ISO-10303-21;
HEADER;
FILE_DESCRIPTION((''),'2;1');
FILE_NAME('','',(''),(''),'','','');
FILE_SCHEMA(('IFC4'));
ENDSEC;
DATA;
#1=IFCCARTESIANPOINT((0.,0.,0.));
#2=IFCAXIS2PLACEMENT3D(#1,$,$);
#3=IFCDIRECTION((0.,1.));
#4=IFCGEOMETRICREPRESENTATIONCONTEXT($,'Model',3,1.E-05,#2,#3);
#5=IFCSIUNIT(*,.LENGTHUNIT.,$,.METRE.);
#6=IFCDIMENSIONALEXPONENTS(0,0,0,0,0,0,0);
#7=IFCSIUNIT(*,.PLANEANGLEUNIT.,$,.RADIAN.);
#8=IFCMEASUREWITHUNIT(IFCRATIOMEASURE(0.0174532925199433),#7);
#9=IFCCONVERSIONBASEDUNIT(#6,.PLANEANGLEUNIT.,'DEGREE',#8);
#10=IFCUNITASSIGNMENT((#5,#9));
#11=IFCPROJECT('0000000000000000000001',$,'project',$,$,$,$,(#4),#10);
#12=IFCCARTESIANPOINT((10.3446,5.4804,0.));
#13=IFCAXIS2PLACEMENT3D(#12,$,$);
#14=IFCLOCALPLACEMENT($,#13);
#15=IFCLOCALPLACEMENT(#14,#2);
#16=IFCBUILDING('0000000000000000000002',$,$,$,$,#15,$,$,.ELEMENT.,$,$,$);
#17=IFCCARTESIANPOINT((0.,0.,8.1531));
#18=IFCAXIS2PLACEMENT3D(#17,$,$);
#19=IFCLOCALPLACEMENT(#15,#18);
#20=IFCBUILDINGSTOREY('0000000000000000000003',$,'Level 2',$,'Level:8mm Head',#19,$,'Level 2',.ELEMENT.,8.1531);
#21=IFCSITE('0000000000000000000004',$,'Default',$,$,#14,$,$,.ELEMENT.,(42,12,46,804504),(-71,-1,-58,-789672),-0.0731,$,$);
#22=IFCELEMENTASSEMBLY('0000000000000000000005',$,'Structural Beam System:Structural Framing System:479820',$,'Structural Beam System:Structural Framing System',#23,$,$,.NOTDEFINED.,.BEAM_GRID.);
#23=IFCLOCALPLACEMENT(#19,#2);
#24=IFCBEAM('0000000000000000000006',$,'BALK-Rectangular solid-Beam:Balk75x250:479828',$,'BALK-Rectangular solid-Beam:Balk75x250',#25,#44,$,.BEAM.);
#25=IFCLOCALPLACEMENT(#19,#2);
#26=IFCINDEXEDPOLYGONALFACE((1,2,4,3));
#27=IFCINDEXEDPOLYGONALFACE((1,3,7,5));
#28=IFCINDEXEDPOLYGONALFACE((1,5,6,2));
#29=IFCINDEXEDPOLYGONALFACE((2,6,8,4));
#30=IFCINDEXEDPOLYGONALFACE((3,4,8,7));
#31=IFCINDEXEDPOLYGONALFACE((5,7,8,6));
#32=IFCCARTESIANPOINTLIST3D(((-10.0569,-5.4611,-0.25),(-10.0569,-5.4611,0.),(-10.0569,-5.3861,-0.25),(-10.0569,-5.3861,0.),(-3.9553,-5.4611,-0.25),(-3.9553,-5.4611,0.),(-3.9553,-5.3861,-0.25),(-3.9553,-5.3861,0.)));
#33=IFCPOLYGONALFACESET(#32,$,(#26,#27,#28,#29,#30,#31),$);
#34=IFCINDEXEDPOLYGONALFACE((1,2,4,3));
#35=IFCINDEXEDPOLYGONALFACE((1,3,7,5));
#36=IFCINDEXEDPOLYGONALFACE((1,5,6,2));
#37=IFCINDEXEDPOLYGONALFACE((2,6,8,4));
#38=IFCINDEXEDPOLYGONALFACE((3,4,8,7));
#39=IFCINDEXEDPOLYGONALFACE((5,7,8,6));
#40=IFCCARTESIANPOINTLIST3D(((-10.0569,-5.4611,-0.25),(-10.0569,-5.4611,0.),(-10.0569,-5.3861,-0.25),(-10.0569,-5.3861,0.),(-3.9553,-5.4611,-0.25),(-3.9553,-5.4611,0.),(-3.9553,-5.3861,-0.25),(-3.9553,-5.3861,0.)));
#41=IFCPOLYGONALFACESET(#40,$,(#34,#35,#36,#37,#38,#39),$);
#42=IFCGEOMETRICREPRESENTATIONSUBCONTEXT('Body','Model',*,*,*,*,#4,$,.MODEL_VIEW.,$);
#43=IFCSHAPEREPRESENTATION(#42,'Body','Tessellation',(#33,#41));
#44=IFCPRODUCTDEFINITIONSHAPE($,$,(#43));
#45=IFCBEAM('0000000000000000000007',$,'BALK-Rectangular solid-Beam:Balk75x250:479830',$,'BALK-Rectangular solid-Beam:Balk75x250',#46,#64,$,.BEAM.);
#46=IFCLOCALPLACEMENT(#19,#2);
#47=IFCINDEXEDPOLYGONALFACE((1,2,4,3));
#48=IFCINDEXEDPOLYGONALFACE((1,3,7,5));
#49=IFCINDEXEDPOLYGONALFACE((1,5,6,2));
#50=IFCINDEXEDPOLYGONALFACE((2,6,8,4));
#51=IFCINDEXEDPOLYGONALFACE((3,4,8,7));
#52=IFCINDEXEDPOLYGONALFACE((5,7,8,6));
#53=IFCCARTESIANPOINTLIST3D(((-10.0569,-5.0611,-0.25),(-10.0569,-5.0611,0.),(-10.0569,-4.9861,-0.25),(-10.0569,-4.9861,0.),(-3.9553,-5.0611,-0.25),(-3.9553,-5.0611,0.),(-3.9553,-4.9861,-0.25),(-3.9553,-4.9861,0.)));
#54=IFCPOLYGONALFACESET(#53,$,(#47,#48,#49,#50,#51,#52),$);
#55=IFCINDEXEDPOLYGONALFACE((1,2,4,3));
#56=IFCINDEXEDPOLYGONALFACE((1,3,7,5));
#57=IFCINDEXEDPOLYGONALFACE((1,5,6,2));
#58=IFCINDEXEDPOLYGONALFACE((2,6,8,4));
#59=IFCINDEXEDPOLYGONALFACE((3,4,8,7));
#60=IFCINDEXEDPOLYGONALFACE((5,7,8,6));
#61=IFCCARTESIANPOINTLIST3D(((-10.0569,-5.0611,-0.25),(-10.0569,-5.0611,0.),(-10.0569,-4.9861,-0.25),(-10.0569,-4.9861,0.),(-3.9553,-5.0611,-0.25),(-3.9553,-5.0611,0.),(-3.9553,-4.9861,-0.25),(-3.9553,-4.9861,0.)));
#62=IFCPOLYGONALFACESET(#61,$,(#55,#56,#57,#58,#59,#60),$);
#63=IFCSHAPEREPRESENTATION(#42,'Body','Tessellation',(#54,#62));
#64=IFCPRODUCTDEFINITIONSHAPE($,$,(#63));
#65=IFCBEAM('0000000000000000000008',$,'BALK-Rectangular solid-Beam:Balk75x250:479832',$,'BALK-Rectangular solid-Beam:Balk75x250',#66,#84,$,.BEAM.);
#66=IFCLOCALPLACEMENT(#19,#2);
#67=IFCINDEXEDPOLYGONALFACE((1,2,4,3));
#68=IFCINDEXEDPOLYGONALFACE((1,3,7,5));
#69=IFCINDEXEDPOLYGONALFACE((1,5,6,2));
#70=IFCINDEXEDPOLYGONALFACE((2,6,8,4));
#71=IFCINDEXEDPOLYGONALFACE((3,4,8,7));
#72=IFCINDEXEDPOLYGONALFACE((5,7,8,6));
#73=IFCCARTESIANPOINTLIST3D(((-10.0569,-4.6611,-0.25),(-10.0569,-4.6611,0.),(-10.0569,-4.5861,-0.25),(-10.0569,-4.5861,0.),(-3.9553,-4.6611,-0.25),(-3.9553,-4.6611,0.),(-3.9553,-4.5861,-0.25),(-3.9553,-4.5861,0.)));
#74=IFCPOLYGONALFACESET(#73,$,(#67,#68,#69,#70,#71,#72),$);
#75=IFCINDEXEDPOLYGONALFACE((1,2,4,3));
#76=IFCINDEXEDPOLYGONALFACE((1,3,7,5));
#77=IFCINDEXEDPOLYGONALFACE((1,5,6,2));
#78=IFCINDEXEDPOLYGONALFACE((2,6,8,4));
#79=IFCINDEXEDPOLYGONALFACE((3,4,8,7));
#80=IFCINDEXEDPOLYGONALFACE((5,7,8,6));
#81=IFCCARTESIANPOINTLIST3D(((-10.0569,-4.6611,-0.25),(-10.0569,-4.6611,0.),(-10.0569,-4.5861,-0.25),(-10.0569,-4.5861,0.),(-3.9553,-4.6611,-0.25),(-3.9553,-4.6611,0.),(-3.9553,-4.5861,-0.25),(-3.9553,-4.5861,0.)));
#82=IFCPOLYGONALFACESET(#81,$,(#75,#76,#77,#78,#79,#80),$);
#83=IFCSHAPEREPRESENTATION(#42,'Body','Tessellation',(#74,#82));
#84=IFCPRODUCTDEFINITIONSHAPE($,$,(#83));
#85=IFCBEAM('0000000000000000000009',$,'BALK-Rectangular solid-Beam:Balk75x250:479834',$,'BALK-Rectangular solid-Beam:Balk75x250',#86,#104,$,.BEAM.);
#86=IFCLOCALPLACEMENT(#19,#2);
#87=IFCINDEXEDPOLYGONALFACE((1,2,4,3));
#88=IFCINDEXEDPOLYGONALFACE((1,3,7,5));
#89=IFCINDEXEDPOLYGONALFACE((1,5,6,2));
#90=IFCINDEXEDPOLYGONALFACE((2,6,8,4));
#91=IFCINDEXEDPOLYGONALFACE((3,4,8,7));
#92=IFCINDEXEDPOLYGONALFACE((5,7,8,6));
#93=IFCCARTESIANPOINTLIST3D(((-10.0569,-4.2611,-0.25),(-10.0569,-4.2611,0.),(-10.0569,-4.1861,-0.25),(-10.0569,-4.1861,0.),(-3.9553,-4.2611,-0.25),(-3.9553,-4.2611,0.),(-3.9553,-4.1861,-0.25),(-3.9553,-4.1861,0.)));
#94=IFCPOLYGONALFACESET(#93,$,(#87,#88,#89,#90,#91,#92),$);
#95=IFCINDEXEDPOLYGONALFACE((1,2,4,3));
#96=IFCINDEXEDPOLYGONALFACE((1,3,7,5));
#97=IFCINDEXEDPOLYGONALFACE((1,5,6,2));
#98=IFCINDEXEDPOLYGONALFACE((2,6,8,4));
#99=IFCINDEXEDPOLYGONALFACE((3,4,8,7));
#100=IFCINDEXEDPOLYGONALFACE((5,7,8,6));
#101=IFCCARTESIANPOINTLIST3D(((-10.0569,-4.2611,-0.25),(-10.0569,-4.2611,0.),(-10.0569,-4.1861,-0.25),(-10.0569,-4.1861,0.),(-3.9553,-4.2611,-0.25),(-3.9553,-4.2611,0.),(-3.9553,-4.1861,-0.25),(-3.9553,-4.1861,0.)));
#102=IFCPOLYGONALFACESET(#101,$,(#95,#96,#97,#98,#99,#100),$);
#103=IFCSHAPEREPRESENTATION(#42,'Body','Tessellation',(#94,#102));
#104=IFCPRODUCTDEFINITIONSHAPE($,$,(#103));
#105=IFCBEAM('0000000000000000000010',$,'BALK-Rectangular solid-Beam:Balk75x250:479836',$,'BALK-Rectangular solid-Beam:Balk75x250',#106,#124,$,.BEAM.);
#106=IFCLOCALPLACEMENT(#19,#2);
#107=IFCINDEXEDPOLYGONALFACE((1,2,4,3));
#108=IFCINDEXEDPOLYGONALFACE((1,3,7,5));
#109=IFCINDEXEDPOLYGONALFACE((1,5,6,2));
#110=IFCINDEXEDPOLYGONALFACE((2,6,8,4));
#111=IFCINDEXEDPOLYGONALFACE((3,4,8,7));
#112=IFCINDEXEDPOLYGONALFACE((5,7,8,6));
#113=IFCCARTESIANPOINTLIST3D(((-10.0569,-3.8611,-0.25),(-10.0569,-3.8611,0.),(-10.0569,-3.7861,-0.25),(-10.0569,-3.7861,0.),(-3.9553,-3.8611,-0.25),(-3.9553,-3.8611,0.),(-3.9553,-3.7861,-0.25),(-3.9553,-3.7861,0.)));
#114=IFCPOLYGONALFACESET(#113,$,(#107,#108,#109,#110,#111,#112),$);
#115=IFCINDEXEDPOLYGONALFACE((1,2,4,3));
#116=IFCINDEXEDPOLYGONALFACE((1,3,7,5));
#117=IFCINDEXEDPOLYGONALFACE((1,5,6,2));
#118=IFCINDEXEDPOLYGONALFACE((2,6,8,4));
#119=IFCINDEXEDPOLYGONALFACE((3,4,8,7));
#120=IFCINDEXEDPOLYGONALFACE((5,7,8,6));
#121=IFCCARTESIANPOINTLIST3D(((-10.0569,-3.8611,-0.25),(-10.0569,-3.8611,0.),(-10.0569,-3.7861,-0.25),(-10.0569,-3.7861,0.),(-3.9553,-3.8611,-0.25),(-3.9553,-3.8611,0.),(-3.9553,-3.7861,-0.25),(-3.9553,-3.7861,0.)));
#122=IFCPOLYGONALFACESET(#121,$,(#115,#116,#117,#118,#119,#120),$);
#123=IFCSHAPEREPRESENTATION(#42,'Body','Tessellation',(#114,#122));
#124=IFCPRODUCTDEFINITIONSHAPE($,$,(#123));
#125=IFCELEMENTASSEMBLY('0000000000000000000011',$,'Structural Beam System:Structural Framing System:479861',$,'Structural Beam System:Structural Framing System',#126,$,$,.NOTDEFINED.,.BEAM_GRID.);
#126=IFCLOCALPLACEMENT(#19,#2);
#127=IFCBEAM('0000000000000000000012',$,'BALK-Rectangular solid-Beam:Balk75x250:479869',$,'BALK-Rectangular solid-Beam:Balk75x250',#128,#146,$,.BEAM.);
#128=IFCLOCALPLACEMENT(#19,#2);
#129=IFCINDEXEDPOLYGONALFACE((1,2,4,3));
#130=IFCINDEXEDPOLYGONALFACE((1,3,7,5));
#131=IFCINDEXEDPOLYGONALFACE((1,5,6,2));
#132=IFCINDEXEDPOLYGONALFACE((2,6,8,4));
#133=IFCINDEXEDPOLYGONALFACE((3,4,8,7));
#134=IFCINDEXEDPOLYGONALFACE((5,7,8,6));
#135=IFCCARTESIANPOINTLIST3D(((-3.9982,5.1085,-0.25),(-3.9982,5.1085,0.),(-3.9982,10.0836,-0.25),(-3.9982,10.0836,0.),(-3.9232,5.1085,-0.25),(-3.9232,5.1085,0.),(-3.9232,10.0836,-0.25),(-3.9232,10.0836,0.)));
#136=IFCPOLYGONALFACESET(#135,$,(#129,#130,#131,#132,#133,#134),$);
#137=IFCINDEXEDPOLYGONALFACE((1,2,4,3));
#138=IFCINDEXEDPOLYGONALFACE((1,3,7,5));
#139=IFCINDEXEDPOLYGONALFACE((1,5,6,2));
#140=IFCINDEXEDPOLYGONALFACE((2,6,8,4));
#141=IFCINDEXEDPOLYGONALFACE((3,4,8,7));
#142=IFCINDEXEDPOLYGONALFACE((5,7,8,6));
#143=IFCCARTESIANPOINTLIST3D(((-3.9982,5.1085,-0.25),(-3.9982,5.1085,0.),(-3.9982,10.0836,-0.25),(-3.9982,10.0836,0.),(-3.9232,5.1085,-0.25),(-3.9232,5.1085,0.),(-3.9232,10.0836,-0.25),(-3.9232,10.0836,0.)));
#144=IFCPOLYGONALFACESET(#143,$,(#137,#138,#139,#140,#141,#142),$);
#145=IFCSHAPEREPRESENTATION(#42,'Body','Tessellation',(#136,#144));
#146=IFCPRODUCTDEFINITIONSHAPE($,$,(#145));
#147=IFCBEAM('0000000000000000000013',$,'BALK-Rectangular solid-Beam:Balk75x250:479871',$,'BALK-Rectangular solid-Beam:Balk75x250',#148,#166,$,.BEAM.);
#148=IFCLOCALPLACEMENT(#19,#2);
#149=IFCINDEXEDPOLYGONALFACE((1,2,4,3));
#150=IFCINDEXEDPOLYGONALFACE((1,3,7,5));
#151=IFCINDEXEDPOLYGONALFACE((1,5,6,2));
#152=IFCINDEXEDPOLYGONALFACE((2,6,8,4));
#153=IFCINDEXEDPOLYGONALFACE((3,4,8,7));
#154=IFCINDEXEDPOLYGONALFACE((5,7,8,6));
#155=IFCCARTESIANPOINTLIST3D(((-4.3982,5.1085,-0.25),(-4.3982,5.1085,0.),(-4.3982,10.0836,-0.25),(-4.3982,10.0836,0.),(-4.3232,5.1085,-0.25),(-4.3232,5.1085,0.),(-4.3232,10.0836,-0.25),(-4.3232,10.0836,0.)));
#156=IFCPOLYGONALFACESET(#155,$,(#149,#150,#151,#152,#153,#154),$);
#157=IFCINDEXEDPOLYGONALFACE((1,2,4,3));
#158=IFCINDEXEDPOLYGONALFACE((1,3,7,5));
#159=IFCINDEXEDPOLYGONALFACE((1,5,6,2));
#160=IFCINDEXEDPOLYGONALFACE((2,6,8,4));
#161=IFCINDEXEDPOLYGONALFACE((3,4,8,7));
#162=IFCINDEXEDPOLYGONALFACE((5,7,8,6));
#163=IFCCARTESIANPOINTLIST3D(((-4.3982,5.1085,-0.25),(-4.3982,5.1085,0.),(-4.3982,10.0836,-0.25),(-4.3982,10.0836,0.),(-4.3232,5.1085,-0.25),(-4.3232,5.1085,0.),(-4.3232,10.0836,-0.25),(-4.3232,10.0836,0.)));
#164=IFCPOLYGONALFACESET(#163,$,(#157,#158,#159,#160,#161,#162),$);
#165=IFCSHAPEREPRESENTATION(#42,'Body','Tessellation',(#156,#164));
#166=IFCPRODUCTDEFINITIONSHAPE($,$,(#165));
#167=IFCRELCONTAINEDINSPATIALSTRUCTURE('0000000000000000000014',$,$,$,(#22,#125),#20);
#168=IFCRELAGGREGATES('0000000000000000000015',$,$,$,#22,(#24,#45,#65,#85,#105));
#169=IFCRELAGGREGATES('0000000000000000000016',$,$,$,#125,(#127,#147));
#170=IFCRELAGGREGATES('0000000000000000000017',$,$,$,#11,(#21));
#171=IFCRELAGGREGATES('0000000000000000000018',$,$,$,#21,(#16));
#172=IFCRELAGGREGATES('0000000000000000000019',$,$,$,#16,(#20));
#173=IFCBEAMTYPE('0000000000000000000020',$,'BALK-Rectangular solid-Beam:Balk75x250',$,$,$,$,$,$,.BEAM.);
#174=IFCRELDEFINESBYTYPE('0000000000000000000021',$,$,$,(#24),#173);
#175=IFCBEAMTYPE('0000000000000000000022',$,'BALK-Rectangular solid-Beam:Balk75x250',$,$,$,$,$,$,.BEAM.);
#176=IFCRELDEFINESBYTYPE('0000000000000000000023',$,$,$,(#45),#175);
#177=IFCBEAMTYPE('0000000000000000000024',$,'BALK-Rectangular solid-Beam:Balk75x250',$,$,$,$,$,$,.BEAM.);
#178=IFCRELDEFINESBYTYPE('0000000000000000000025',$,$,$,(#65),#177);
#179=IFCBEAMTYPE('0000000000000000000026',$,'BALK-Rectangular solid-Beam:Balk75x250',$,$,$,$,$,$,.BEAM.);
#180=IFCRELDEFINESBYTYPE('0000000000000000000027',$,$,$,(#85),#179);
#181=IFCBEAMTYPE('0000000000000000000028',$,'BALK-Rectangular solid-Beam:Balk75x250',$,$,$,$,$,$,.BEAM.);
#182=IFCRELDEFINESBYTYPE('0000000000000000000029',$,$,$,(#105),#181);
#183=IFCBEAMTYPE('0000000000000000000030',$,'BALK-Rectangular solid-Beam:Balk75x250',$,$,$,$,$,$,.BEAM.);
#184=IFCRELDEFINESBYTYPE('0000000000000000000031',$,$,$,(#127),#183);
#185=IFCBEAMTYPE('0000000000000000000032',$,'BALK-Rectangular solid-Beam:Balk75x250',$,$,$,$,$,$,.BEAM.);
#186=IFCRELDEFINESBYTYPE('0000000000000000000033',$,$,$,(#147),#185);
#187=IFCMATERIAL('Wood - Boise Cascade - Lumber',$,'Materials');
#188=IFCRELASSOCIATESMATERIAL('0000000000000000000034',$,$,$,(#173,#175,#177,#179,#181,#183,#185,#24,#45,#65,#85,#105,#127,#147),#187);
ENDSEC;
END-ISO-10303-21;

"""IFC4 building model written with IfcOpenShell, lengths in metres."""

from ifc_helpers import new_model, entity, si_unit, converted_unit, direction, frame, frame_2d, origin, place, context, subcontext, project, spatial, rectangle, extrude, source, transform, mapped, material, material_profile, profile_set, profile_usage, type_object, type_shapes, element, aggregate, save


model = new_model("IFC4")

# Units and contexts
model_context = context("Model", 3, precision=1e-05, world=origin(), true_north=direction((0.0, 1.0)))
body_context = subcontext(model_context, "Body", "Model", "MODEL_VIEW")
ifc_project = project(units=[si_unit("LENGTHUNIT", "METRE"), converted_unit("PLANEANGLEUNIT", "DEGREE", entity("IfcRatioMeasure", 0.0174532925199433), si_unit("PLANEANGLEUNIT", "RADIAN"), dimensions=[0, 0, 0, 0, 0, 0, 0])], contexts=[model_context])

# Site, building, storey
site_placement = place(None, frame((10.3446, 5.4804, 0.0)))
site = spatial("IfcSite", under=ifc_project, at=site_placement, Name="Default", CompositionType="ELEMENT", RefLatitude=(42, 12, 46, 804504), RefLongitude=(-71, -1, -58, -789672), RefElevation=-0.0731)
building_placement = place(site_placement, origin())
building = spatial("IfcBuilding", under=site, at=building_placement, CompositionType="ELEMENT")
storey_placement = place(building_placement, frame((0.0, 0.0, 8.1531)))
storey = spatial("IfcBuildingStorey", under=building, at=storey_placement, Name="Level 2", ObjectType="Level:8mm Head", LongName="Level 2", CompositionType="ELEMENT", Elevation=8.1531)

# Element assemblies, beams
assembly_1_placement = place(storey_placement, origin())
assembly_1 = element("IfcElementAssembly", 1, at=assembly_1_placement, inside=storey, Name="Structural Beam System:Structural Framing System:479820", ObjectType="Structural Beam System:Structural Framing System", AssemblyPlace="NOTDEFINED", PredefinedType="BEAM_GRID")
ifc_material = material(Name="Wood - Boise Cascade - Lumber", Category="Materials")
ifc_material_profile = material_profile(ifc_material, rectangle(XDim=0.25, YDim=0.075, at=frame_2d((0.0, 0.0), x_axis=(1.0, 0.0))), Name="Balk75x250")
ifc_profile_set = profile_set([ifc_material_profile], Name="Balk75x250")
ifc_profile_usage_1 = profile_usage(ifc_profile_set, cardinal=8)
beam_type_1 = type_object("IfcBeamType", Name="BALK-Rectangular solid-Beam:Balk75x250", PredefinedType="BEAM", material=ifc_profile_set)
shared_shape_1 = source(origin(), body_context, "Body", "SweptSolid", [
    extrude(rectangle(XDim=0.25, YDim=0.075, at=frame_2d((0.0, 0.0), x_axis=(1.0, 0.0))), frame((-10.0569, -5.4236, 8.0281), z_axis=(1.0, 0.0, 0.0), x_axis=(0.0, 0.0, -1.0)), (0.0, 0.0, 1.0), 6.1016),
    extrude(rectangle(XDim=0.25, YDim=0.075, at=frame_2d((0.0, 0.0), x_axis=(1.0, 0.0))), frame((-10.0569, -5.4236, 8.0281), z_axis=(1.0, 0.0, 0.0), x_axis=(0.0, 0.0, -1.0)), (0.0, 0.0, 1.0), 6.1016),
])
type_shapes(beam_type_1, [shared_shape_1])
beam_1_placement = place(assembly_1_placement, frame((0.0, 0.0, -8.1531)))
beam_1 = element("IfcBeam", 2, at=beam_1_placement, type_object=beam_type_1, material=ifc_profile_usage_1, Name="BALK-Rectangular solid-Beam:Balk75x250:479828", ObjectType="BALK-Rectangular solid-Beam:Balk75x250", PredefinedType="BEAM", context=body_context, shape_type="MappedRepresentation", body=[
    mapped(shared_shape_1, transform((0.0, 0.0, 0.0), scale=1.0)),
])
ifc_profile_usage_2 = profile_usage(ifc_profile_set, cardinal=8)
beam_type_2 = type_object("IfcBeamType", Name="BALK-Rectangular solid-Beam:Balk75x250", PredefinedType="BEAM", material=ifc_profile_set)
shared_shape_2 = source(origin(), body_context, "Body", "SweptSolid", [
    extrude(rectangle(XDim=0.25, YDim=0.075, at=frame_2d((0.0, 0.0), x_axis=(1.0, 0.0))), frame((-10.0569, -5.0236, 8.0281), z_axis=(1.0, 0.0, 0.0), x_axis=(0.0, 0.0, -1.0)), (0.0, 0.0, 1.0), 6.1016),
    extrude(rectangle(XDim=0.25, YDim=0.075, at=frame_2d((0.0, 0.0), x_axis=(1.0, 0.0))), frame((-10.0569, -5.0236, 8.0281), z_axis=(1.0, 0.0, 0.0), x_axis=(0.0, 0.0, -1.0)), (0.0, 0.0, 1.0), 6.1016),
])
type_shapes(beam_type_2, [shared_shape_2])
beam_2_placement = place(assembly_1_placement, frame((0.0, 0.0, -8.1531)))
beam_2 = element("IfcBeam", 3, at=beam_2_placement, type_object=beam_type_2, material=ifc_profile_usage_2, Name="BALK-Rectangular solid-Beam:Balk75x250:479830", ObjectType="BALK-Rectangular solid-Beam:Balk75x250", PredefinedType="BEAM", context=body_context, shape_type="MappedRepresentation", body=[
    mapped(shared_shape_2, transform((0.0, 0.0, 0.0), scale=1.0)),
])
ifc_profile_usage_3 = profile_usage(ifc_profile_set, cardinal=8)
beam_type_3 = type_object("IfcBeamType", Name="BALK-Rectangular solid-Beam:Balk75x250", PredefinedType="BEAM", material=ifc_profile_set)
shared_shape_3 = source(origin(), body_context, "Body", "SweptSolid", [
    extrude(rectangle(XDim=0.25, YDim=0.075, at=frame_2d((0.0, 0.0), x_axis=(1.0, 0.0))), frame((-10.0569, -4.6236, 8.0281), z_axis=(1.0, 0.0, 0.0), x_axis=(0.0, 0.0, -1.0)), (0.0, 0.0, 1.0), 6.1016),
    extrude(rectangle(XDim=0.25, YDim=0.075, at=frame_2d((0.0, 0.0), x_axis=(1.0, 0.0))), frame((-10.0569, -4.6236, 8.0281), z_axis=(1.0, 0.0, 0.0), x_axis=(0.0, 0.0, -1.0)), (0.0, 0.0, 1.0), 6.1016),
])
type_shapes(beam_type_3, [shared_shape_3])
beam_3_placement = place(assembly_1_placement, frame((0.0, 0.0, -8.1531)))
beam_3 = element("IfcBeam", 4, at=beam_3_placement, type_object=beam_type_3, material=ifc_profile_usage_3, Name="BALK-Rectangular solid-Beam:Balk75x250:479832", ObjectType="BALK-Rectangular solid-Beam:Balk75x250", PredefinedType="BEAM", context=body_context, shape_type="MappedRepresentation", body=[
    mapped(shared_shape_3, transform((0.0, 0.0, 0.0), scale=1.0)),
])
ifc_profile_usage_4 = profile_usage(ifc_profile_set, cardinal=8)
beam_type_4 = type_object("IfcBeamType", Name="BALK-Rectangular solid-Beam:Balk75x250", PredefinedType="BEAM", material=ifc_profile_set)
shared_shape_4 = source(origin(), body_context, "Body", "SweptSolid", [
    extrude(rectangle(XDim=0.25, YDim=0.075, at=frame_2d((0.0, 0.0), x_axis=(1.0, 0.0))), frame((-10.0569, -4.2236, 8.0281), z_axis=(1.0, 0.0, 0.0), x_axis=(0.0, 0.0, -1.0)), (0.0, 0.0, 1.0), 6.1016),
    extrude(rectangle(XDim=0.25, YDim=0.075, at=frame_2d((0.0, 0.0), x_axis=(1.0, 0.0))), frame((-10.0569, -4.2236, 8.0281), z_axis=(1.0, 0.0, 0.0), x_axis=(0.0, 0.0, -1.0)), (0.0, 0.0, 1.0), 6.1016),
])
type_shapes(beam_type_4, [shared_shape_4])
beam_4_placement = place(assembly_1_placement, frame((0.0, 0.0, -8.1531)))
beam_4 = element("IfcBeam", 5, at=beam_4_placement, type_object=beam_type_4, material=ifc_profile_usage_4, Name="BALK-Rectangular solid-Beam:Balk75x250:479834", ObjectType="BALK-Rectangular solid-Beam:Balk75x250", PredefinedType="BEAM", context=body_context, shape_type="MappedRepresentation", body=[
    mapped(shared_shape_4, transform((0.0, 0.0, 0.0), scale=1.0)),
])
ifc_profile_usage_5 = profile_usage(ifc_profile_set, cardinal=8)
beam_type_5 = type_object("IfcBeamType", Name="BALK-Rectangular solid-Beam:Balk75x250", PredefinedType="BEAM", material=ifc_profile_set)
shared_shape_5 = source(origin(), body_context, "Body", "SweptSolid", [
    extrude(rectangle(XDim=0.25, YDim=0.075, at=frame_2d((0.0, 0.0), x_axis=(1.0, 0.0))), frame((-10.0569, -3.8236, 8.0281), z_axis=(1.0, 0.0, 0.0), x_axis=(0.0, 0.0, -1.0)), (0.0, 0.0, 1.0), 6.1016),
    extrude(rectangle(XDim=0.25, YDim=0.075, at=frame_2d((0.0, 0.0), x_axis=(1.0, 0.0))), frame((-10.0569, -3.8236, 8.0281), z_axis=(1.0, 0.0, 0.0), x_axis=(0.0, 0.0, -1.0)), (0.0, 0.0, 1.0), 6.1016),
])
type_shapes(beam_type_5, [shared_shape_5])
beam_5_placement = place(assembly_1_placement, frame((0.0, 0.0, -8.1531)))
beam_5 = element("IfcBeam", 6, at=beam_5_placement, type_object=beam_type_5, material=ifc_profile_usage_5, Name="BALK-Rectangular solid-Beam:Balk75x250:479836", ObjectType="BALK-Rectangular solid-Beam:Balk75x250", PredefinedType="BEAM", context=body_context, shape_type="MappedRepresentation", body=[
    mapped(shared_shape_5, transform((0.0, 0.0, 0.0), scale=1.0)),
])
aggregate(assembly_1, [beam_1, beam_2, beam_3, beam_4, beam_5])
assembly_2_placement = place(storey_placement, origin())
assembly_2 = element("IfcElementAssembly", 7, at=assembly_2_placement, inside=storey, Name="Structural Beam System:Structural Framing System:479861", ObjectType="Structural Beam System:Structural Framing System", AssemblyPlace="NOTDEFINED", PredefinedType="BEAM_GRID")
ifc_profile_usage_6 = profile_usage(ifc_profile_set, cardinal=8)
beam_type_6 = type_object("IfcBeamType", Name="BALK-Rectangular solid-Beam:Balk75x250", PredefinedType="BEAM", material=ifc_profile_set)
shared_shape_6 = source(origin(), body_context, "Body", "SweptSolid", [
    extrude(rectangle(XDim=0.25, YDim=0.075, at=frame_2d((0.0, 0.0), x_axis=(0.0, 1.0))), frame((-3.9607, 10.0836, 8.0281), z_axis=(0.0, -1.0, 0.0), x_axis=(-1.0, 0.0, 0.0)), (0.0, 0.0, 1.0), 4.9751),
    extrude(rectangle(XDim=0.25, YDim=0.075, at=frame_2d((0.0, 0.0), x_axis=(0.0, 1.0))), frame((-3.9607, 10.0836, 8.0281), z_axis=(0.0, -1.0, 0.0), x_axis=(-1.0, 0.0, 0.0)), (0.0, 0.0, 1.0), 4.9751),
])
type_shapes(beam_type_6, [shared_shape_6])
beam_6_placement = place(assembly_2_placement, frame((0.0, 0.0, -8.1531)))
beam_6 = element("IfcBeam", 8, at=beam_6_placement, type_object=beam_type_6, material=ifc_profile_usage_6, Name="BALK-Rectangular solid-Beam:Balk75x250:479869", ObjectType="BALK-Rectangular solid-Beam:Balk75x250", PredefinedType="BEAM", context=body_context, shape_type="MappedRepresentation", body=[
    mapped(shared_shape_6, transform((0.0, 0.0, 0.0), scale=1.0)),
])
ifc_profile_usage_7 = profile_usage(ifc_profile_set, cardinal=8)
beam_type_7 = type_object("IfcBeamType", Name="BALK-Rectangular solid-Beam:Balk75x250", PredefinedType="BEAM", material=ifc_profile_set)
shared_shape_7 = source(origin(), body_context, "Body", "SweptSolid", [
    extrude(rectangle(XDim=0.25, YDim=0.075, at=frame_2d((0.0, 0.0), x_axis=(0.0, 1.0))), frame((-4.3607, 10.0836, 8.0281), z_axis=(0.0, -1.0, 0.0), x_axis=(-1.0, 0.0, 0.0)), (0.0, 0.0, 1.0), 4.9751),
    extrude(rectangle(XDim=0.25, YDim=0.075, at=frame_2d((0.0, 0.0), x_axis=(0.0, 1.0))), frame((-4.3607, 10.0836, 8.0281), z_axis=(0.0, -1.0, 0.0), x_axis=(-1.0, 0.0, 0.0)), (0.0, 0.0, 1.0), 4.9751),
])
type_shapes(beam_type_7, [shared_shape_7])
beam_7_placement = place(assembly_2_placement, frame((0.0, 0.0, -8.1531)))
beam_7 = element("IfcBeam", 9, at=beam_7_placement, type_object=beam_type_7, material=ifc_profile_usage_7, Name="BALK-Rectangular solid-Beam:Balk75x250:479871", ObjectType="BALK-Rectangular solid-Beam:Balk75x250", PredefinedType="BEAM", context=body_context, shape_type="MappedRepresentation", body=[
    mapped(shared_shape_7, transform((0.0, 0.0, 0.0), scale=1.0)),
])
aggregate(assembly_2, [beam_6, beam_7])

save(model, "model.ifc")
